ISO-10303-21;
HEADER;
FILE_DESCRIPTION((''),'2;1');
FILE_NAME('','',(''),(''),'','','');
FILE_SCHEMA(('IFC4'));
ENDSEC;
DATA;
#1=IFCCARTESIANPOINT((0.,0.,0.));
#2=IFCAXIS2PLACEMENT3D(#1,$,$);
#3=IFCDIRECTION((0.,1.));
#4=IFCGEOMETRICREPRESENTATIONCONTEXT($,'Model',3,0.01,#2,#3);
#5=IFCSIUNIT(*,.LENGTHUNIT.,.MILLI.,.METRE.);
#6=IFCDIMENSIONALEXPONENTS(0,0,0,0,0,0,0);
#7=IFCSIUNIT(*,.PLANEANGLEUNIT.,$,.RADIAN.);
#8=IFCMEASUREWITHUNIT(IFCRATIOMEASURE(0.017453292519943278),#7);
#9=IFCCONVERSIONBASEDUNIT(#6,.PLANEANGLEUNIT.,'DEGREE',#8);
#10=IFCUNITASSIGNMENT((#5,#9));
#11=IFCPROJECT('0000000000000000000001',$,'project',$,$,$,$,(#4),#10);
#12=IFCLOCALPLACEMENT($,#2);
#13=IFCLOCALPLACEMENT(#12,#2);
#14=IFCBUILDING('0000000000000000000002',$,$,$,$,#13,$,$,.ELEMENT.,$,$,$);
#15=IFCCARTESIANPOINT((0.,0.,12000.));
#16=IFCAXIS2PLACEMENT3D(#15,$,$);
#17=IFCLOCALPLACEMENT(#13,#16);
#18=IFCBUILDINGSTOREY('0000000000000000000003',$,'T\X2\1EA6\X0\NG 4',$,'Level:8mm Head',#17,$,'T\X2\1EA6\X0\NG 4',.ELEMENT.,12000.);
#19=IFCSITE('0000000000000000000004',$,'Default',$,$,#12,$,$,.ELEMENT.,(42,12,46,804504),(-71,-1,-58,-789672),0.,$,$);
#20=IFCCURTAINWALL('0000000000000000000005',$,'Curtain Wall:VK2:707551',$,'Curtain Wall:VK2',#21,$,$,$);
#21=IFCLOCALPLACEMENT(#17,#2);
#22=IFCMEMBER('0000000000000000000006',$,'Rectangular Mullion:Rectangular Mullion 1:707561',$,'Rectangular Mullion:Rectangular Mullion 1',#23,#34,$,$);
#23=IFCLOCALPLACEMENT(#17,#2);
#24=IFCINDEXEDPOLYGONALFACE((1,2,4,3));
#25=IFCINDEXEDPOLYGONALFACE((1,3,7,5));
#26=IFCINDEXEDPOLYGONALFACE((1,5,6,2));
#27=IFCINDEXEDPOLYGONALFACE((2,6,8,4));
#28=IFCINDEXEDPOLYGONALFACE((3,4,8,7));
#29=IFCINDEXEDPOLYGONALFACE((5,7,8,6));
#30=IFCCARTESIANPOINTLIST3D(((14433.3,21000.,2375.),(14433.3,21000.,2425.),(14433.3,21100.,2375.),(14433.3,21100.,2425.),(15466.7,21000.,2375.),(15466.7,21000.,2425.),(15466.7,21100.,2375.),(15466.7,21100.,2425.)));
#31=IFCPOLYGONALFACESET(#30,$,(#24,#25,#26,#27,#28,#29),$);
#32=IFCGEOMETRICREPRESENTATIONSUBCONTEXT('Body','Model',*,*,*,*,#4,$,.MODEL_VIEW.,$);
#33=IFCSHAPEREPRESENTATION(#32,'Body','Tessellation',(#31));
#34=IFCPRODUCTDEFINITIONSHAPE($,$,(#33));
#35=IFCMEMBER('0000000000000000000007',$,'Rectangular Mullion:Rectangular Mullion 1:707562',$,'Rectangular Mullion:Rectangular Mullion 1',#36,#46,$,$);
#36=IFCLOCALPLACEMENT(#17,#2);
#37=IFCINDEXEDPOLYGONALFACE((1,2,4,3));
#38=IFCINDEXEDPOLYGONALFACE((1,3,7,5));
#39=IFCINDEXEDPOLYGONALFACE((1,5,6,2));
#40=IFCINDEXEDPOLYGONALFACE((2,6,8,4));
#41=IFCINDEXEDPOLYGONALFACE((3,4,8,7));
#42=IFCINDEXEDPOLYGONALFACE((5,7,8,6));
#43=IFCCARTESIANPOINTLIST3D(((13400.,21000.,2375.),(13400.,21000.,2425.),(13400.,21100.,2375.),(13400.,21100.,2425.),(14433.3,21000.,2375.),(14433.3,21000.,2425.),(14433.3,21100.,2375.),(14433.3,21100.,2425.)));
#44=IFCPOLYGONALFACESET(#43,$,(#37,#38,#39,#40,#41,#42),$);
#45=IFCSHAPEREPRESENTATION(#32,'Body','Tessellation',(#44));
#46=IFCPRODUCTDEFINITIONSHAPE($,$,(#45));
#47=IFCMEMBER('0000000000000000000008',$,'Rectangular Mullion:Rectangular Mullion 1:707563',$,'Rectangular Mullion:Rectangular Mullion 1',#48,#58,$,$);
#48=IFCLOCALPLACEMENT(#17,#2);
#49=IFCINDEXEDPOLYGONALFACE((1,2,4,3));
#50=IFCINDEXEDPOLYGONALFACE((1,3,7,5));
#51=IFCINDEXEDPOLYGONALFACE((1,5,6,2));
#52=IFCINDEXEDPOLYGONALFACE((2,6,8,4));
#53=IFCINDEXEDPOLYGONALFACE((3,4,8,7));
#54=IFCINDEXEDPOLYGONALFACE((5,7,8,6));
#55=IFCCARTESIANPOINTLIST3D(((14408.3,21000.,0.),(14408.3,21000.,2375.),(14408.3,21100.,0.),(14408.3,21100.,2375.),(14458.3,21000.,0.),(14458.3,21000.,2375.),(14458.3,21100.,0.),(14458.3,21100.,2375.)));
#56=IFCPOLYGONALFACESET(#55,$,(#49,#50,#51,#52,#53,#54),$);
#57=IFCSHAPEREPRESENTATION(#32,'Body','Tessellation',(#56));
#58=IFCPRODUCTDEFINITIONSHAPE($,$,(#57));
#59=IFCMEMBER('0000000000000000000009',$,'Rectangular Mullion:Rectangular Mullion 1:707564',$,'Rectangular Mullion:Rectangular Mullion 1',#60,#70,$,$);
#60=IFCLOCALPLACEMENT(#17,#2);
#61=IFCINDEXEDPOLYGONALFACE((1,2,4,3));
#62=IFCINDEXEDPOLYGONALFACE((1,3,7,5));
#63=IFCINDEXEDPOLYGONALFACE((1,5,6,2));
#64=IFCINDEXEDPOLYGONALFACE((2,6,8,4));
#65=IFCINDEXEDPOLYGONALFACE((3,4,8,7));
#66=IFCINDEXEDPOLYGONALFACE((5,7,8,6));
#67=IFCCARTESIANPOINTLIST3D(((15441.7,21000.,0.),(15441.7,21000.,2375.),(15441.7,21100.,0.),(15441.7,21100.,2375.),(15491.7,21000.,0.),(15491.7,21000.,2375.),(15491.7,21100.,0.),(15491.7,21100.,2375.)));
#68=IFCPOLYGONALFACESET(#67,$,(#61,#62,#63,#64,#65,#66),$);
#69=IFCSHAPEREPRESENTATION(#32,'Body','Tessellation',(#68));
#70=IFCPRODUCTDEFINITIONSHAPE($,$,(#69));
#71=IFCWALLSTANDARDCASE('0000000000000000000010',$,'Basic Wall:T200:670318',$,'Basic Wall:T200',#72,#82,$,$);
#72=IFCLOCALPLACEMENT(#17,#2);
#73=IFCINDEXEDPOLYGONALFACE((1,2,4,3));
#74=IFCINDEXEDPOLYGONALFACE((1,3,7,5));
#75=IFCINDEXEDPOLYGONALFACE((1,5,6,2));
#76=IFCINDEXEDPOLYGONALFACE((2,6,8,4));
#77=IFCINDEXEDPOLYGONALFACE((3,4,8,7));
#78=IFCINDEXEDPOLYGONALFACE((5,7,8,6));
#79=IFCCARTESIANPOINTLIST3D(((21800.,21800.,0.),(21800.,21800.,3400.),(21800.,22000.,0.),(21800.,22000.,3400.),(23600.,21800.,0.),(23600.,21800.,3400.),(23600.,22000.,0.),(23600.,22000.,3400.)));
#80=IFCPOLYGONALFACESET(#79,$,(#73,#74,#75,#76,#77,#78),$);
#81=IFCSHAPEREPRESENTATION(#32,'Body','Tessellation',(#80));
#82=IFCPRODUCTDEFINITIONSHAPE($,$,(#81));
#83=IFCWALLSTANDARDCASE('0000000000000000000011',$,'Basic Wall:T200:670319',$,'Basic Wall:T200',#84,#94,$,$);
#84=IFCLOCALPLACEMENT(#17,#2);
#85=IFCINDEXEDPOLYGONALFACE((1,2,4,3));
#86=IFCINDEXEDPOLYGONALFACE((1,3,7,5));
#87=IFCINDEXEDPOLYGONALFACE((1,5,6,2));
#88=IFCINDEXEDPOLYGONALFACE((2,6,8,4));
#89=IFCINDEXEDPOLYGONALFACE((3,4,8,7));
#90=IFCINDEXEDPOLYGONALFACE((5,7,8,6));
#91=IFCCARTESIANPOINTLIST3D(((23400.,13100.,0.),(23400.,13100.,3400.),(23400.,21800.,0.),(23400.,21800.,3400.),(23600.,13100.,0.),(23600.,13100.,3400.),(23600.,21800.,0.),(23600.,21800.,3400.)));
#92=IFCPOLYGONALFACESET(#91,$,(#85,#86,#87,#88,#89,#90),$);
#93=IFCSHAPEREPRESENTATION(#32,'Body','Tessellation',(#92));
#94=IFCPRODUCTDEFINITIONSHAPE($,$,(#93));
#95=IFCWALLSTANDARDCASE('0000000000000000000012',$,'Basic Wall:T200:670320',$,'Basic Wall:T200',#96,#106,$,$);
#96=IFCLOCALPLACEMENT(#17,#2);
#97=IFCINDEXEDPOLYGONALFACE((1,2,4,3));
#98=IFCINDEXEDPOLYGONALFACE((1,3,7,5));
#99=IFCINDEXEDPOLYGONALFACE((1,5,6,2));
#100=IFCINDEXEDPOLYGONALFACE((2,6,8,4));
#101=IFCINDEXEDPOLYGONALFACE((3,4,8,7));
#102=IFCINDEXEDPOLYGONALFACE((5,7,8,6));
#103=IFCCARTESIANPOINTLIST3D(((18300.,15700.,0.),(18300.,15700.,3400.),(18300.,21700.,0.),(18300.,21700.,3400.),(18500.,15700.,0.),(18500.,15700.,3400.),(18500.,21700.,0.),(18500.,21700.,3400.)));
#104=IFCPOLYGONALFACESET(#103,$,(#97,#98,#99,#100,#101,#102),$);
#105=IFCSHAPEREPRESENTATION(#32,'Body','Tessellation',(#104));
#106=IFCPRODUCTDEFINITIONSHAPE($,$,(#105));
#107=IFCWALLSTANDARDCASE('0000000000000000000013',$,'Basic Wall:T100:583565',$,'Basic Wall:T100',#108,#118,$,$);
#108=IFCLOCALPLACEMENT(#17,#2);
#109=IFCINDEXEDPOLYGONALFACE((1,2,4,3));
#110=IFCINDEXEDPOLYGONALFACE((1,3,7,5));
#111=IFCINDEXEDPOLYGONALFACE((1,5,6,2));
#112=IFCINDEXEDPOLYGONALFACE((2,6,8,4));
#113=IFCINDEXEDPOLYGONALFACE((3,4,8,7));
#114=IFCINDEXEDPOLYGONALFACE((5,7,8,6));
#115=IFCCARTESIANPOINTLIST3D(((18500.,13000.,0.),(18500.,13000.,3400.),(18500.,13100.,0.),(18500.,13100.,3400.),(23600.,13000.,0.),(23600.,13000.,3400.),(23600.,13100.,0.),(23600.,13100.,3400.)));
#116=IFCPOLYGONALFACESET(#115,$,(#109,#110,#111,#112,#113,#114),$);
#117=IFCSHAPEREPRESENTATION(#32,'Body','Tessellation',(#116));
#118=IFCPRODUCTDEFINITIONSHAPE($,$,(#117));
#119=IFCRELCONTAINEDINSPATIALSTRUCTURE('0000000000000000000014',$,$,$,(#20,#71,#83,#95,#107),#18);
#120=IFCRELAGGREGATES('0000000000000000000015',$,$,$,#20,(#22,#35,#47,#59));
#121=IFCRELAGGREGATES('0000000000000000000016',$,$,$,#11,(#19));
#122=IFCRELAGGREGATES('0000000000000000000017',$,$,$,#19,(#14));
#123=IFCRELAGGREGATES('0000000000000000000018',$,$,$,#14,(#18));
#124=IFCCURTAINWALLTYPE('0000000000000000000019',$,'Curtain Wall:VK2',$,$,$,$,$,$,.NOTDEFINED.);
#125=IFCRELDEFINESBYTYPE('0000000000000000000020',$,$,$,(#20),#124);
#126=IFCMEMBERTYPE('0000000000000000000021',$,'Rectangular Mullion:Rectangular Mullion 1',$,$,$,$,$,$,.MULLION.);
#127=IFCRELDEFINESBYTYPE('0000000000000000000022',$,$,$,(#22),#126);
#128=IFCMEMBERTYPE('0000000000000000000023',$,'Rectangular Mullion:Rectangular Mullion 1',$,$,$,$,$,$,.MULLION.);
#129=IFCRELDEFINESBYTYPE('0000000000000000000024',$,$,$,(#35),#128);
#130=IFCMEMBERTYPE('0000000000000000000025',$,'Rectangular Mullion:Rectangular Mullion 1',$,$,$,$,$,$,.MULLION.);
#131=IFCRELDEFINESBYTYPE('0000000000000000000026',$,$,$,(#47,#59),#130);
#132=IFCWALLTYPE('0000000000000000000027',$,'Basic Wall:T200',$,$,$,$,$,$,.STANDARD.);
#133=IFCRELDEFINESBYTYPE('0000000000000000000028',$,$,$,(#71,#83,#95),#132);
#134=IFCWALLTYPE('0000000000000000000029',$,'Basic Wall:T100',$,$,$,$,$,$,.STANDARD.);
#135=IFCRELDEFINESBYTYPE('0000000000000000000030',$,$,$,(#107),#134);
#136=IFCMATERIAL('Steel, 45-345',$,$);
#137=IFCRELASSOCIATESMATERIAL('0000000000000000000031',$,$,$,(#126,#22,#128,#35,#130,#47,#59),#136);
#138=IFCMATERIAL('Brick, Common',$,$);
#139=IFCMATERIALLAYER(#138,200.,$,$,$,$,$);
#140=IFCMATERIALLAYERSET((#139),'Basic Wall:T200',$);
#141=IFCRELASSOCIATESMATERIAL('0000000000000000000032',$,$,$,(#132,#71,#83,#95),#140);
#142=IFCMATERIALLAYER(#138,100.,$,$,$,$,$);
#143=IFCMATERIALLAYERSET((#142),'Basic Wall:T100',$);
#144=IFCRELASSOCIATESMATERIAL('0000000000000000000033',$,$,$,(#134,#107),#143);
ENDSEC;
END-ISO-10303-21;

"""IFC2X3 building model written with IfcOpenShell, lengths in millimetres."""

from ifc_helpers import new_model, entity, si_unit, converted_unit, direction, frame, frame_2d, origin, origin_2d_with_axis, place, context, subcontext, project, spatial, rectangle, extrude, source, transform, mapped, material, layer, layer_set, layer_usage, type_object, type_shapes, element, aggregate, save


model = new_model("IFC2X3")

# Units and contexts
model_context = context("Model", 3, precision=0.01, world=origin(), true_north=direction((0.0, 1.0)))
body_context = subcontext(model_context, "Body", "Model", "MODEL_VIEW")
ifc_project = project(units=[si_unit("LENGTHUNIT", "METRE", prefix="MILLI"), converted_unit("PLANEANGLEUNIT", "DEGREE", entity("IfcRatioMeasure", 0.017453292519943278), si_unit("PLANEANGLEUNIT", "RADIAN"), dimensions=[0, 0, 0, 0, 0, 0, 0])], contexts=[model_context])

# Site, building, storey
site_placement = place(None, origin())
site = spatial("IfcSite", under=ifc_project, at=site_placement, Name="Default", CompositionType="ELEMENT", RefLatitude=(42, 12, 46, 804504), RefLongitude=(-71, -1, -58, -789672), RefElevation=0.0)
building_placement = place(site_placement, origin())
building = spatial("IfcBuilding", under=site, at=building_placement, CompositionType="ELEMENT")
storey_placement = place(building_placement, frame((0.0, 0.0, 12000.0)))
storey = spatial("IfcBuildingStorey", under=building, at=storey_placement, Name="TẦNG 4", ObjectType="Level:8mm Head", LongName="TẦNG 4", CompositionType="ELEMENT", Elevation=12000.0)

# Curtain wall, members
curtain_wall_type = type_object("IfcCurtainWallType", Name="Curtain Wall:VK2", PredefinedType="NOTDEFINED")
curtain_wall_placement = place(storey_placement, frame((0.0, 0.0, -12000.0)))
curtain_wall = element("IfcCurtainWall", 1, at=curtain_wall_placement, inside=storey, type_object=curtain_wall_type, Name="Curtain Wall:VK2:707551", ObjectType="Curtain Wall:VK2")
ifc_material_1 = material(Name="Steel, 45-345")
member_type_1 = type_object("IfcMemberType", Name="Rectangular Mullion:Rectangular Mullion 1", PredefinedType="MULLION", material=ifc_material_1)
shared_shape_1 = source(origin(), body_context, "Body", "SweptSolid", [
    extrude(rectangle(XDim=100.0, YDim=50.0, at=origin_2d_with_axis()), frame((0.0, 50.0, -1033.3), z_axis=(0.0, 0.0, 1.0), x_axis=(0.0, -1.0, 0.0)), (0.0, 0.0, 1.0), 1033.3),
])
type_shapes(member_type_1, [shared_shape_1])
member_1_placement = place(curtain_wall_placement, frame((15466.7, 21100.0, 14400.0), z_axis=(1.0, 0.0, 0.0), x_axis=(0.0, 0.0, 1.0)))
member_1 = element("IfcMember", 2, at=member_1_placement, type_object=member_type_1, material=ifc_material_1, Name="Rectangular Mullion:Rectangular Mullion 1:707561", ObjectType="Rectangular Mullion:Rectangular Mullion 1", context=body_context, shape_type="MappedRepresentation", body=[
    mapped(shared_shape_1, transform((0.0, 0.0, 0.0), scale=1.0)),
])
member_type_2 = type_object("IfcMemberType", Name="Rectangular Mullion:Rectangular Mullion 1", PredefinedType="MULLION", material=ifc_material_1)
shared_shape_2 = source(origin(), body_context, "Body", "SweptSolid", [
    extrude(rectangle(XDim=100.0, YDim=50.0, at=origin_2d_with_axis()), frame((0.0, 50.0, -1033.3), z_axis=(0.0, 0.0, 1.0), x_axis=(0.0, -1.0, 0.0)), (0.0, 0.0, 1.0), 1033.3),
])
type_shapes(member_type_2, [shared_shape_2])
member_2_placement = place(curtain_wall_placement, frame((14433.3, 21100.0, 14400.0), z_axis=(1.0, 0.0, 0.0), x_axis=(0.0, 0.0, 1.0)))
member_2 = element("IfcMember", 3, at=member_2_placement, type_object=member_type_2, material=ifc_material_1, Name="Rectangular Mullion:Rectangular Mullion 1:707562", ObjectType="Rectangular Mullion:Rectangular Mullion 1", context=body_context, shape_type="MappedRepresentation", body=[
    mapped(shared_shape_2, transform((0.0, 0.0, 0.0), scale=1.0)),
])
member_type_3 = type_object("IfcMemberType", Name="Rectangular Mullion:Rectangular Mullion 1", PredefinedType="MULLION", material=ifc_material_1)
shared_shape_3 = source(origin(), body_context, "Body", "SweptSolid", [
    extrude(rectangle(XDim=100.0, YDim=50.0, at=origin_2d_with_axis()), frame((0.0, 50.0, -2375.0), z_axis=(0.0, 0.0, 1.0), x_axis=(0.0, -1.0, 0.0)), (0.0, 0.0, 1.0), 2375.0),
])
type_shapes(member_type_3, [shared_shape_3])
member_3_placement = place(curtain_wall_placement, frame((14433.3, 21100.0, 12000.0), z_axis=(0.0, 0.0, -1.0), x_axis=(1.0, 0.0, 0.0)))
member_3 = element("IfcMember", 4, at=member_3_placement, type_object=member_type_3, material=ifc_material_1, Name="Rectangular Mullion:Rectangular Mullion 1:707563", ObjectType="Rectangular Mullion:Rectangular Mullion 1", context=body_context, shape_type="MappedRepresentation", body=[
    mapped(shared_shape_3, transform((0.0, 0.0, 0.0), scale=1.0)),
])
member_4_placement = place(curtain_wall_placement, frame((15466.7, 21100.0, 12000.0), z_axis=(0.0, 0.0, -1.0), x_axis=(1.0, 0.0, 0.0)))
member_4 = element("IfcMember", 5, at=member_4_placement, type_object=member_type_3, material=ifc_material_1, Name="Rectangular Mullion:Rectangular Mullion 1:707564", ObjectType="Rectangular Mullion:Rectangular Mullion 1", context=body_context, shape_type="MappedRepresentation", body=[
    mapped(shared_shape_3, transform((0.0, 0.0, 0.0), scale=1.0)),
])
aggregate(curtain_wall, [member_1, member_2, member_3, member_4])

# Walls
ifc_material_2 = material(Name="Brick, Common")
ifc_layer_1 = layer(ifc_material_2, 200.0)
ifc_layer_set_1 = layer_set([ifc_layer_1], Name="Basic Wall:T200")
ifc_layer_usage_1 = layer_usage(ifc_layer_set_1, "AXIS2", "NEGATIVE", 100.0)
wall_type_1 = type_object("IfcWallType", Name="Basic Wall:T200", PredefinedType="STANDARD", material=ifc_layer_set_1)
wall_1_placement = place(storey_placement, frame((21800.0, 21900.0, 0.0)))
element("IfcWallStandardCase", 6, at=wall_1_placement, inside=storey, type_object=wall_type_1, material=ifc_layer_usage_1, Name="Basic Wall:T200:670318", ObjectType="Basic Wall:T200", context=body_context, shape_type="SweptSolid", body=[
    extrude(rectangle(XDim=1800.0, YDim=200.0, at=frame_2d((900.0, 0.0), x_axis=(-1.0, 0.0))), origin(), (0.0, 0.0, 1.0), 3400.0),
])
wall_2_placement = place(storey_placement, frame((23500.0, 21800.0, 0.0), z_axis=(0.0, 0.0, 1.0), x_axis=(0.0, -1.0, 0.0)))
element("IfcWallStandardCase", 7, at=wall_2_placement, inside=storey, type_object=wall_type_1, material=ifc_layer_usage_1, Name="Basic Wall:T200:670319", ObjectType="Basic Wall:T200", context=body_context, shape_type="SweptSolid", body=[
    extrude(rectangle(XDim=8700.0, YDim=200.0, at=frame_2d((4350.0, 0.0), x_axis=(-1.0, 0.0))), origin(), (0.0, 0.0, 1.0), 3400.0),
])
wall_3_placement = place(storey_placement, frame((18400.0, 15700.0, 0.0), z_axis=(0.0, 0.0, 1.0), x_axis=(0.0, 1.0, 0.0)))
element("IfcWallStandardCase", 8, at=wall_3_placement, inside=storey, type_object=wall_type_1, material=ifc_layer_usage_1, Name="Basic Wall:T200:670320", ObjectType="Basic Wall:T200", context=body_context, shape_type="SweptSolid", body=[
    extrude(rectangle(XDim=6000.0, YDim=200.0, at=frame_2d((3000.0, 0.0), x_axis=(-1.0, 0.0))), origin(), (0.0, 0.0, 1.0), 3400.0),
])
ifc_layer_2 = layer(ifc_material_2, 100.0)
ifc_layer_set_2 = layer_set([ifc_layer_2], Name="Basic Wall:T100")
ifc_layer_usage_2 = layer_usage(ifc_layer_set_2, "AXIS2", "POSITIVE", -50.0)
wall_type_2 = type_object("IfcWallType", Name="Basic Wall:T100", PredefinedType="STANDARD", material=ifc_layer_set_2)
wall_4_placement = place(storey_placement, frame((18500.0, 13050.0, 0.0)))
element("IfcWallStandardCase", 9, at=wall_4_placement, inside=storey, type_object=wall_type_2, material=ifc_layer_usage_2, Name="Basic Wall:T100:583565", ObjectType="Basic Wall:T100", context=body_context, shape_type="SweptSolid", body=[
    extrude(rectangle(XDim=5100.0, YDim=100.0, at=frame_2d((2550.0, 0.0), x_axis=(-1.0, 0.0))), origin(), (0.0, 0.0, 1.0), 3400.0),
])

save(model, "model.ifc")
